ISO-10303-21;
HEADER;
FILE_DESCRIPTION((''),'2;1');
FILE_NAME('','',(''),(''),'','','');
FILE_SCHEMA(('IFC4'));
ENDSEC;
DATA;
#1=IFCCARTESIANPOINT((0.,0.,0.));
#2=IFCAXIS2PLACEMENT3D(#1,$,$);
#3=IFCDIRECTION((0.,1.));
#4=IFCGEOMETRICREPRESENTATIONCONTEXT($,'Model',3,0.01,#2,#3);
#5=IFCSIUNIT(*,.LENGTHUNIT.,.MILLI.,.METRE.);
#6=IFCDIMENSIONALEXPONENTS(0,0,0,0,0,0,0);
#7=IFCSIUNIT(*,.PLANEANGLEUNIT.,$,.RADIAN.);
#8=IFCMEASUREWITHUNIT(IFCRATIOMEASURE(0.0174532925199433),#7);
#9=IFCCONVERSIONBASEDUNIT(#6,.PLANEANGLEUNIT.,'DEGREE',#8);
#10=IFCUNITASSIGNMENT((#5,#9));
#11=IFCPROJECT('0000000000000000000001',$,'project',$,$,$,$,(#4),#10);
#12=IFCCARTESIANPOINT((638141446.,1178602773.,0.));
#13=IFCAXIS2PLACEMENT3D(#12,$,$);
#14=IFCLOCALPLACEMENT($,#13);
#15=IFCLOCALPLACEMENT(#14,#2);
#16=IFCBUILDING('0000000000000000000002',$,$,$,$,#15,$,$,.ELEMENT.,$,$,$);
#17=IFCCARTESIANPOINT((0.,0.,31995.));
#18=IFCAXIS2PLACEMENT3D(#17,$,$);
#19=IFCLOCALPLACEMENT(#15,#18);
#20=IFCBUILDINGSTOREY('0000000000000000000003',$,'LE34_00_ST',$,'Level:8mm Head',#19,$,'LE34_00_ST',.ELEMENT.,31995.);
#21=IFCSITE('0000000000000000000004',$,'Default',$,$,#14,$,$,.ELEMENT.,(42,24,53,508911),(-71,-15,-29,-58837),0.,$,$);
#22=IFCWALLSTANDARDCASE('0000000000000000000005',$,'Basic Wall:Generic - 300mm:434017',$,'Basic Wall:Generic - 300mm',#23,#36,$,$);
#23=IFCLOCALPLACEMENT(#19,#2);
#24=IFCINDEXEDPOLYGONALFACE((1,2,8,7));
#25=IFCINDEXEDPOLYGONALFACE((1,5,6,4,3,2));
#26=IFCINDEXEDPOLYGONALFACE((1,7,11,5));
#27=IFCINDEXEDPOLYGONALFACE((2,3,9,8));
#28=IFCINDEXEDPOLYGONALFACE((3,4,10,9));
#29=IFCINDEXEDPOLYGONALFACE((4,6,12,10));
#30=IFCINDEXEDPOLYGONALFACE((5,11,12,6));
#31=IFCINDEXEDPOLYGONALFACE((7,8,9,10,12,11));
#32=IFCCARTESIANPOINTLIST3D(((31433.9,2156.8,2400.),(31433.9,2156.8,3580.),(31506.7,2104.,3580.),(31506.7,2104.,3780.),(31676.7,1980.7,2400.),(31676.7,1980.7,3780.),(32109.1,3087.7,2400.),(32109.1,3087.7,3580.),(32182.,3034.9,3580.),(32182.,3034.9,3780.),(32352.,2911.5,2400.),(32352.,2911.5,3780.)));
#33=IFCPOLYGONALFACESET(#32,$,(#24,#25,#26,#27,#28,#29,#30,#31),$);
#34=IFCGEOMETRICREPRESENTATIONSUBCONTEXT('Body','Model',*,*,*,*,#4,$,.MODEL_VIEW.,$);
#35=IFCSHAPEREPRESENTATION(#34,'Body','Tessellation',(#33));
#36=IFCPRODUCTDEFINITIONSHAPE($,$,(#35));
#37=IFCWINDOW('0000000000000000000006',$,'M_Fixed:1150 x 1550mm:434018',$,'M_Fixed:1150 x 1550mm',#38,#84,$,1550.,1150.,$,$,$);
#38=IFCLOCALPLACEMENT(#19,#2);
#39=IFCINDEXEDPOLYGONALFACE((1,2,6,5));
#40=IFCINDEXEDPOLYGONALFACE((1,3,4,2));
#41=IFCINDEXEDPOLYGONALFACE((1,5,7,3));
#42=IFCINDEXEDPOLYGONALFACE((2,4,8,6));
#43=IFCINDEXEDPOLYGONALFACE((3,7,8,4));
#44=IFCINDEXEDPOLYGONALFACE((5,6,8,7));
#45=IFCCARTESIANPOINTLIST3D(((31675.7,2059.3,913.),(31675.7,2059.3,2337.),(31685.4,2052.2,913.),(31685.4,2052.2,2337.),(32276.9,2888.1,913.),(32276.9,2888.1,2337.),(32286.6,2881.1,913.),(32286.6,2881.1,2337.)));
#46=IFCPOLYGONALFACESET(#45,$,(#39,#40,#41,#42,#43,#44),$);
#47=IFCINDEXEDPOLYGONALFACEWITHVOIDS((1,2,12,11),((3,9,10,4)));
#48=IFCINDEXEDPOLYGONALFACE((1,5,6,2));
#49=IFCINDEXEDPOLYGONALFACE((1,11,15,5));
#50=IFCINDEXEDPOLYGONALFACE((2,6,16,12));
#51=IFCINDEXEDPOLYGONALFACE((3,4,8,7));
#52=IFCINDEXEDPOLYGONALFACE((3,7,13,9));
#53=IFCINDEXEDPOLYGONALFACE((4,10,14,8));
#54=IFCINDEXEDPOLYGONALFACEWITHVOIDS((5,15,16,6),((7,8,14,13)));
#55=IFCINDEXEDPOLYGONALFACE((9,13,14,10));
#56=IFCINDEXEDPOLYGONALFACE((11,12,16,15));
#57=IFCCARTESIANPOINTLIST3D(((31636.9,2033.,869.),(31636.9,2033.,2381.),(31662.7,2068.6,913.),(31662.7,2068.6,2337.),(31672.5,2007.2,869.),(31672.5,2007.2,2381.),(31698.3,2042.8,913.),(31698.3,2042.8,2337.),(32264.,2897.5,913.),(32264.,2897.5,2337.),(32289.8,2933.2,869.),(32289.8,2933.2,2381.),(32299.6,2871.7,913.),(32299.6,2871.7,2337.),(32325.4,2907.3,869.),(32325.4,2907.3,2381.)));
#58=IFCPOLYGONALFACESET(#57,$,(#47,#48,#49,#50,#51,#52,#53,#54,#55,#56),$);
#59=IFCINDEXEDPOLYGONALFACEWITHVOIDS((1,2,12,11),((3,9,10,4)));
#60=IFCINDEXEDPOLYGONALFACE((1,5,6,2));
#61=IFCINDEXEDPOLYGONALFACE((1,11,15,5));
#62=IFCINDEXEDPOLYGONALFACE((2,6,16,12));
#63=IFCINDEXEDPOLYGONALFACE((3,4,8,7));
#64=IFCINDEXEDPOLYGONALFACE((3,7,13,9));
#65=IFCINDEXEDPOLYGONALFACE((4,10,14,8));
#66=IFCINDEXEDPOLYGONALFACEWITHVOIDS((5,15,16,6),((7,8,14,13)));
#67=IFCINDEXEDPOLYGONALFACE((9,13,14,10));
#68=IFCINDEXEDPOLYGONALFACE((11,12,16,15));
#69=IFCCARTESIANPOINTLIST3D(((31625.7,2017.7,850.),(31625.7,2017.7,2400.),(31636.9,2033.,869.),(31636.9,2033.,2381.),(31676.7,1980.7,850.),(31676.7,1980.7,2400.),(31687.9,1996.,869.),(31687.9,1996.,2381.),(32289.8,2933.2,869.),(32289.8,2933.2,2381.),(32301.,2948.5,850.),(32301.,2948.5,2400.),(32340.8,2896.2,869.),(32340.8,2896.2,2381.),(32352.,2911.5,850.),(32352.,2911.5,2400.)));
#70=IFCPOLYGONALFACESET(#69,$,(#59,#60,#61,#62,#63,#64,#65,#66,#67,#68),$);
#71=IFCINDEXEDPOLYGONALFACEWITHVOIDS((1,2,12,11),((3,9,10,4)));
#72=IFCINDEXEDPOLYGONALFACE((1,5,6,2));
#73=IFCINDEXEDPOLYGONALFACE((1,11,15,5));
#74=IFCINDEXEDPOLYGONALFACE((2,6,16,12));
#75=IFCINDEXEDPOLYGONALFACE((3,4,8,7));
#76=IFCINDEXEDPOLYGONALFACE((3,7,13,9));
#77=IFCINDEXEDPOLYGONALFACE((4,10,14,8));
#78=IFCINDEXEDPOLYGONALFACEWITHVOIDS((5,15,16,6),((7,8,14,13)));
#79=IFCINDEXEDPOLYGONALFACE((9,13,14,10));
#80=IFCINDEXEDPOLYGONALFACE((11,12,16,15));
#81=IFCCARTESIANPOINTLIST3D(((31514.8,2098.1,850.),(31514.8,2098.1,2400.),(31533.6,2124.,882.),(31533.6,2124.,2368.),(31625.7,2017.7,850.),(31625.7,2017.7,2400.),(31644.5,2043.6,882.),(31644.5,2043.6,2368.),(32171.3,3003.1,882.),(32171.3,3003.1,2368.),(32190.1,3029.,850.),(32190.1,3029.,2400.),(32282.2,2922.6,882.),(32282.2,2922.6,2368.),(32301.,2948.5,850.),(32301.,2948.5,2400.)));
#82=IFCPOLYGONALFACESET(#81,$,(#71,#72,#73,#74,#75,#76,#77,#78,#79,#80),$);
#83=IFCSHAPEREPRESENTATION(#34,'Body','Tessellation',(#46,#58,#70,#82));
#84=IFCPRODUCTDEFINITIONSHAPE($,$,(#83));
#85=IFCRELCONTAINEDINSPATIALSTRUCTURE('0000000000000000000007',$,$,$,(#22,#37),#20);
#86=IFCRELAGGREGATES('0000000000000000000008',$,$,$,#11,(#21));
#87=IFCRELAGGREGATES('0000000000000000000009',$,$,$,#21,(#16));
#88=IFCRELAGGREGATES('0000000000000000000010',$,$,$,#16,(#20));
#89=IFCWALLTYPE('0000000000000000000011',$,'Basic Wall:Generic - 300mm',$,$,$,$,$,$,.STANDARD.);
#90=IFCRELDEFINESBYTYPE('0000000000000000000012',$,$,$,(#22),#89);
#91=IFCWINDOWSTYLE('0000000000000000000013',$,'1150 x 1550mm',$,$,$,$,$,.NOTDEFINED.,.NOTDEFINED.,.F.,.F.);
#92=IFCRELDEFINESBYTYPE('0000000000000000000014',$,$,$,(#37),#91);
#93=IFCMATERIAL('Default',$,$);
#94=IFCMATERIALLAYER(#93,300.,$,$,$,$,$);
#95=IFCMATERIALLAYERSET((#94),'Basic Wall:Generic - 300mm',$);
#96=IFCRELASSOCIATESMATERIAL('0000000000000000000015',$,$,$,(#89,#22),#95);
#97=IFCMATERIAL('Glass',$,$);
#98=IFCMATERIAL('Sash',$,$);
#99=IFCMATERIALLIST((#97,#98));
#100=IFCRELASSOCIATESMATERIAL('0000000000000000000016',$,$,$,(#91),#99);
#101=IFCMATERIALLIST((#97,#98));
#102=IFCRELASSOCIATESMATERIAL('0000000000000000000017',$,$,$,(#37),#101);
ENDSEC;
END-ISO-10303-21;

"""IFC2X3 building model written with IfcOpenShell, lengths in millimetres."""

from ifc_helpers import new_model, entity, si_unit, converted_unit, direction, frame, frame_2d, origin, place, context, subcontext, project, spatial, polyline, rectangle, outline, extrude, clip, bounded_halfspace, source, transform, mapped, material, material_list, layer, layer_set, layer_usage, type_object, type_shapes, element, fill, save


model = new_model("IFC2X3")

# Units and contexts
model_context = context("Model", 3, precision=0.01, world=origin(), true_north=direction((0.0, 1.0)))
body_context = subcontext(model_context, "Body", "Model", "MODEL_VIEW")
ifc_project = project(units=[si_unit("LENGTHUNIT", "METRE", prefix="MILLI"), converted_unit("PLANEANGLEUNIT", "DEGREE", entity("IfcRatioMeasure", 0.0174532925199433), si_unit("PLANEANGLEUNIT", "RADIAN"), dimensions=[0, 0, 0, 0, 0, 0, 0])], contexts=[model_context])

# Site, building, storey
site_placement = place(None, frame((638141446.0, 1178602773.0, 0.0)))
site = spatial("IfcSite", under=ifc_project, at=site_placement, Name="Default", CompositionType="ELEMENT", RefLatitude=(42, 24, 53, 508911), RefLongitude=(-71, -15, -29, -58837), RefElevation=0.0)
building_placement = place(site_placement, origin())
building = spatial("IfcBuilding", under=site, at=building_placement, CompositionType="ELEMENT")
storey_placement = place(building_placement, frame((0.0, 0.0, 31995.0)))
storey = spatial("IfcBuildingStorey", under=building, at=storey_placement, Name="LE34_00_ST", ObjectType="Level:8mm Head", LongName="LE34_00_ST", CompositionType="ELEMENT", Elevation=31995.0)

# Shared definitions
ifc_material_1 = material(Name="Default")

# Wall, opening, window
ifc_layer_1 = layer(ifc_material_1, 300.0)
ifc_layer_set_1 = layer_set([ifc_layer_1], Name="Basic Wall:Generic - 300mm")
wall_type_1 = type_object("IfcWallType", Name="Basic Wall:Generic - 300mm", PredefinedType="STANDARD", material=ifc_layer_set_1)
ifc_material_2 = material(Name="Glass")
ifc_material_3 = material(Name="Sash")
ifc_material_list_1 = material_list([ifc_material_2, ifc_material_3])
window_style = type_object("IfcWindowStyle", Name="1150 x 1550mm", ConstructionType="NOTDEFINED", OperationType="NOTDEFINED", ParameterTakesPrecedence=False, Sizeable=False, material=ifc_material_list_1)
shared_shape_1 = source(origin(), body_context, "Body", "SweptSolid", [
    extrude(rectangle(XDim=1024.0, YDim=12.0, at=frame_2d((0.0, 0.0), x_axis=(1.0, 0.0))), frame((575.0, 285.0, 63.0), z_axis=(0.0, 0.0, 1.0), x_axis=(-1.0, 0.0, 0.0)), (0.0, 0.0, 1.0), 1424.0),
    extrude(outline(polyline([(-556.0, -756.0), (556.0, -756.0), (556.0, 756.0), (-556.0, 756.0), (-556.0, -756.0)]), holes=[polyline([(-512.0, -712.0), (-512.0, 712.0), (512.0, 712.0), (512.0, -712.0), (-512.0, -712.0)])]), frame((575.0, 307.0, 775.0), z_axis=(0.0, -1.0, 0.0), x_axis=(-1.0, 0.0, 0.0)), (0.0, 0.0, 1.0), 44.0),
    extrude(outline(polyline([(-575.0, -775.0), (575.0, -775.0), (575.0, 775.0), (-575.0, 775.0), (-575.0, -775.0)]), holes=[polyline([(-556.0, -756.0), (-556.0, 756.0), (556.0, 756.0), (556.0, -756.0), (-556.0, -756.0)])]), frame((575.0, 326.0, 775.0), z_axis=(0.0, -1.0, 0.0), x_axis=(-1.0, 0.0, 0.0)), (0.0, 0.0, 1.0), 63.0),
    extrude(outline(polyline([(-575.0, -775.0), (575.0, -775.0), (575.0, 775.0), (-575.0, 775.0), (-575.0, -775.0)]), holes=[polyline([(-543.0, -743.0), (-543.0, 743.0), (543.0, 743.0), (543.0, -743.0), (-543.0, -743.0)])]), frame((575.0, 263.0, 775.0), z_axis=(0.0, -1.0, 0.0), x_axis=(-1.0, 0.0, 0.0)), (0.0, 0.0, 1.0), 137.0),
])
type_shapes(window_style, [shared_shape_1])
ifc_layer_usage_1 = layer_usage(ifc_layer_set_1, "AXIS2", "POSITIVE", -150.0)
wall_1_placement = place(storey_placement, frame((31555.3, 2068.7, 2400.0), z_axis=(0.0, 0.0, 1.0), x_axis=(0.587164, 0.809468, 0.0)))
wall_1 = element("IfcWallStandardCase", 1, at=wall_1_placement, inside=storey, type_object=wall_type_1, material=ifc_layer_usage_1, Name="Basic Wall:Generic - 300mm:434017", ObjectType="Basic Wall:Generic - 300mm", context=body_context, shape_type="Clipping", body=[
    clip(clip(extrude(rectangle(XDim=1150.0, YDim=300.0, at=frame_2d((575.0, 0.0), x_axis=(-1.0, 0.0))), origin(), (0.0, 0.0, 1.0), 1380.0), bounded_halfspace(frame((0.0, 60.0, 1180.0), z_axis=(0.0, 0.0, -1.0), x_axis=(0.0, 1.0, 0.0)), True, frame((0.0, 60.0, 1180.0), z_axis=(0.0, 0.0, -1.0), x_axis=(0.0, 1.0, 0.0)), polyline([(0.0, 0.0), (90.0, 0.0), (90.0, 1150.0), (0.0, 1150.0), (0.0, 0.0)]))), bounded_halfspace(frame((1150.0, 60.0, 1180.0), z_axis=(0.0, -1.0, 0.0), x_axis=(0.0, 0.0, 1.0)), True, frame((1150.0, 60.0, 1180.0), z_axis=(0.0, -1.0, 0.0), x_axis=(0.0, 0.0, 1.0)), polyline([(0.0, 0.0), (200.0, 0.0), (200.0, 1150.0), (0.0, 1150.0), (0.0, 0.0)]))),
])
opening_1_placement = place(wall_1_placement, frame((1150.0, 150.0, -1550.0)))
opening_1 = element("IfcOpeningElement", 2, at=opening_1_placement, cuts=wall_1, ObjectType="Opening", context=body_context, shape_type="SweptSolid", body=[
    extrude(rectangle(XDim=1550.0, YDim=1150.0, at=frame_2d((775.0, 575.0), x_axis=(1.0, 0.0))), frame((0.0, 0.0, 0.0), z_axis=(0.0, -1.0, 0.0), x_axis=(0.0, 0.0, 1.0)), (0.0, 0.0, 1.0), 300.0),
])
ifc_material_list_2 = material_list([ifc_material_2, ifc_material_3])
window_1_placement = place(opening_1_placement, frame((0.0, 26.0, 0.0), z_axis=(0.0, 0.0, 1.0), x_axis=(-1.0, 0.0, 0.0)))
window_1 = element("IfcWindow", 3, at=window_1_placement, inside=storey, type_object=window_style, material=ifc_material_list_2, Name="M_Fixed:1150 x 1550mm:434018", ObjectType="M_Fixed:1150 x 1550mm", OverallHeight=1550.0, OverallWidth=1150.0, context=body_context, shape_type="MappedRepresentation", body=[
    mapped(shared_shape_1, transform((0.0, 0.0, 0.0), scale=1.0)),
])
fill(opening_1, window_1)

save(model, "model.ifc")
